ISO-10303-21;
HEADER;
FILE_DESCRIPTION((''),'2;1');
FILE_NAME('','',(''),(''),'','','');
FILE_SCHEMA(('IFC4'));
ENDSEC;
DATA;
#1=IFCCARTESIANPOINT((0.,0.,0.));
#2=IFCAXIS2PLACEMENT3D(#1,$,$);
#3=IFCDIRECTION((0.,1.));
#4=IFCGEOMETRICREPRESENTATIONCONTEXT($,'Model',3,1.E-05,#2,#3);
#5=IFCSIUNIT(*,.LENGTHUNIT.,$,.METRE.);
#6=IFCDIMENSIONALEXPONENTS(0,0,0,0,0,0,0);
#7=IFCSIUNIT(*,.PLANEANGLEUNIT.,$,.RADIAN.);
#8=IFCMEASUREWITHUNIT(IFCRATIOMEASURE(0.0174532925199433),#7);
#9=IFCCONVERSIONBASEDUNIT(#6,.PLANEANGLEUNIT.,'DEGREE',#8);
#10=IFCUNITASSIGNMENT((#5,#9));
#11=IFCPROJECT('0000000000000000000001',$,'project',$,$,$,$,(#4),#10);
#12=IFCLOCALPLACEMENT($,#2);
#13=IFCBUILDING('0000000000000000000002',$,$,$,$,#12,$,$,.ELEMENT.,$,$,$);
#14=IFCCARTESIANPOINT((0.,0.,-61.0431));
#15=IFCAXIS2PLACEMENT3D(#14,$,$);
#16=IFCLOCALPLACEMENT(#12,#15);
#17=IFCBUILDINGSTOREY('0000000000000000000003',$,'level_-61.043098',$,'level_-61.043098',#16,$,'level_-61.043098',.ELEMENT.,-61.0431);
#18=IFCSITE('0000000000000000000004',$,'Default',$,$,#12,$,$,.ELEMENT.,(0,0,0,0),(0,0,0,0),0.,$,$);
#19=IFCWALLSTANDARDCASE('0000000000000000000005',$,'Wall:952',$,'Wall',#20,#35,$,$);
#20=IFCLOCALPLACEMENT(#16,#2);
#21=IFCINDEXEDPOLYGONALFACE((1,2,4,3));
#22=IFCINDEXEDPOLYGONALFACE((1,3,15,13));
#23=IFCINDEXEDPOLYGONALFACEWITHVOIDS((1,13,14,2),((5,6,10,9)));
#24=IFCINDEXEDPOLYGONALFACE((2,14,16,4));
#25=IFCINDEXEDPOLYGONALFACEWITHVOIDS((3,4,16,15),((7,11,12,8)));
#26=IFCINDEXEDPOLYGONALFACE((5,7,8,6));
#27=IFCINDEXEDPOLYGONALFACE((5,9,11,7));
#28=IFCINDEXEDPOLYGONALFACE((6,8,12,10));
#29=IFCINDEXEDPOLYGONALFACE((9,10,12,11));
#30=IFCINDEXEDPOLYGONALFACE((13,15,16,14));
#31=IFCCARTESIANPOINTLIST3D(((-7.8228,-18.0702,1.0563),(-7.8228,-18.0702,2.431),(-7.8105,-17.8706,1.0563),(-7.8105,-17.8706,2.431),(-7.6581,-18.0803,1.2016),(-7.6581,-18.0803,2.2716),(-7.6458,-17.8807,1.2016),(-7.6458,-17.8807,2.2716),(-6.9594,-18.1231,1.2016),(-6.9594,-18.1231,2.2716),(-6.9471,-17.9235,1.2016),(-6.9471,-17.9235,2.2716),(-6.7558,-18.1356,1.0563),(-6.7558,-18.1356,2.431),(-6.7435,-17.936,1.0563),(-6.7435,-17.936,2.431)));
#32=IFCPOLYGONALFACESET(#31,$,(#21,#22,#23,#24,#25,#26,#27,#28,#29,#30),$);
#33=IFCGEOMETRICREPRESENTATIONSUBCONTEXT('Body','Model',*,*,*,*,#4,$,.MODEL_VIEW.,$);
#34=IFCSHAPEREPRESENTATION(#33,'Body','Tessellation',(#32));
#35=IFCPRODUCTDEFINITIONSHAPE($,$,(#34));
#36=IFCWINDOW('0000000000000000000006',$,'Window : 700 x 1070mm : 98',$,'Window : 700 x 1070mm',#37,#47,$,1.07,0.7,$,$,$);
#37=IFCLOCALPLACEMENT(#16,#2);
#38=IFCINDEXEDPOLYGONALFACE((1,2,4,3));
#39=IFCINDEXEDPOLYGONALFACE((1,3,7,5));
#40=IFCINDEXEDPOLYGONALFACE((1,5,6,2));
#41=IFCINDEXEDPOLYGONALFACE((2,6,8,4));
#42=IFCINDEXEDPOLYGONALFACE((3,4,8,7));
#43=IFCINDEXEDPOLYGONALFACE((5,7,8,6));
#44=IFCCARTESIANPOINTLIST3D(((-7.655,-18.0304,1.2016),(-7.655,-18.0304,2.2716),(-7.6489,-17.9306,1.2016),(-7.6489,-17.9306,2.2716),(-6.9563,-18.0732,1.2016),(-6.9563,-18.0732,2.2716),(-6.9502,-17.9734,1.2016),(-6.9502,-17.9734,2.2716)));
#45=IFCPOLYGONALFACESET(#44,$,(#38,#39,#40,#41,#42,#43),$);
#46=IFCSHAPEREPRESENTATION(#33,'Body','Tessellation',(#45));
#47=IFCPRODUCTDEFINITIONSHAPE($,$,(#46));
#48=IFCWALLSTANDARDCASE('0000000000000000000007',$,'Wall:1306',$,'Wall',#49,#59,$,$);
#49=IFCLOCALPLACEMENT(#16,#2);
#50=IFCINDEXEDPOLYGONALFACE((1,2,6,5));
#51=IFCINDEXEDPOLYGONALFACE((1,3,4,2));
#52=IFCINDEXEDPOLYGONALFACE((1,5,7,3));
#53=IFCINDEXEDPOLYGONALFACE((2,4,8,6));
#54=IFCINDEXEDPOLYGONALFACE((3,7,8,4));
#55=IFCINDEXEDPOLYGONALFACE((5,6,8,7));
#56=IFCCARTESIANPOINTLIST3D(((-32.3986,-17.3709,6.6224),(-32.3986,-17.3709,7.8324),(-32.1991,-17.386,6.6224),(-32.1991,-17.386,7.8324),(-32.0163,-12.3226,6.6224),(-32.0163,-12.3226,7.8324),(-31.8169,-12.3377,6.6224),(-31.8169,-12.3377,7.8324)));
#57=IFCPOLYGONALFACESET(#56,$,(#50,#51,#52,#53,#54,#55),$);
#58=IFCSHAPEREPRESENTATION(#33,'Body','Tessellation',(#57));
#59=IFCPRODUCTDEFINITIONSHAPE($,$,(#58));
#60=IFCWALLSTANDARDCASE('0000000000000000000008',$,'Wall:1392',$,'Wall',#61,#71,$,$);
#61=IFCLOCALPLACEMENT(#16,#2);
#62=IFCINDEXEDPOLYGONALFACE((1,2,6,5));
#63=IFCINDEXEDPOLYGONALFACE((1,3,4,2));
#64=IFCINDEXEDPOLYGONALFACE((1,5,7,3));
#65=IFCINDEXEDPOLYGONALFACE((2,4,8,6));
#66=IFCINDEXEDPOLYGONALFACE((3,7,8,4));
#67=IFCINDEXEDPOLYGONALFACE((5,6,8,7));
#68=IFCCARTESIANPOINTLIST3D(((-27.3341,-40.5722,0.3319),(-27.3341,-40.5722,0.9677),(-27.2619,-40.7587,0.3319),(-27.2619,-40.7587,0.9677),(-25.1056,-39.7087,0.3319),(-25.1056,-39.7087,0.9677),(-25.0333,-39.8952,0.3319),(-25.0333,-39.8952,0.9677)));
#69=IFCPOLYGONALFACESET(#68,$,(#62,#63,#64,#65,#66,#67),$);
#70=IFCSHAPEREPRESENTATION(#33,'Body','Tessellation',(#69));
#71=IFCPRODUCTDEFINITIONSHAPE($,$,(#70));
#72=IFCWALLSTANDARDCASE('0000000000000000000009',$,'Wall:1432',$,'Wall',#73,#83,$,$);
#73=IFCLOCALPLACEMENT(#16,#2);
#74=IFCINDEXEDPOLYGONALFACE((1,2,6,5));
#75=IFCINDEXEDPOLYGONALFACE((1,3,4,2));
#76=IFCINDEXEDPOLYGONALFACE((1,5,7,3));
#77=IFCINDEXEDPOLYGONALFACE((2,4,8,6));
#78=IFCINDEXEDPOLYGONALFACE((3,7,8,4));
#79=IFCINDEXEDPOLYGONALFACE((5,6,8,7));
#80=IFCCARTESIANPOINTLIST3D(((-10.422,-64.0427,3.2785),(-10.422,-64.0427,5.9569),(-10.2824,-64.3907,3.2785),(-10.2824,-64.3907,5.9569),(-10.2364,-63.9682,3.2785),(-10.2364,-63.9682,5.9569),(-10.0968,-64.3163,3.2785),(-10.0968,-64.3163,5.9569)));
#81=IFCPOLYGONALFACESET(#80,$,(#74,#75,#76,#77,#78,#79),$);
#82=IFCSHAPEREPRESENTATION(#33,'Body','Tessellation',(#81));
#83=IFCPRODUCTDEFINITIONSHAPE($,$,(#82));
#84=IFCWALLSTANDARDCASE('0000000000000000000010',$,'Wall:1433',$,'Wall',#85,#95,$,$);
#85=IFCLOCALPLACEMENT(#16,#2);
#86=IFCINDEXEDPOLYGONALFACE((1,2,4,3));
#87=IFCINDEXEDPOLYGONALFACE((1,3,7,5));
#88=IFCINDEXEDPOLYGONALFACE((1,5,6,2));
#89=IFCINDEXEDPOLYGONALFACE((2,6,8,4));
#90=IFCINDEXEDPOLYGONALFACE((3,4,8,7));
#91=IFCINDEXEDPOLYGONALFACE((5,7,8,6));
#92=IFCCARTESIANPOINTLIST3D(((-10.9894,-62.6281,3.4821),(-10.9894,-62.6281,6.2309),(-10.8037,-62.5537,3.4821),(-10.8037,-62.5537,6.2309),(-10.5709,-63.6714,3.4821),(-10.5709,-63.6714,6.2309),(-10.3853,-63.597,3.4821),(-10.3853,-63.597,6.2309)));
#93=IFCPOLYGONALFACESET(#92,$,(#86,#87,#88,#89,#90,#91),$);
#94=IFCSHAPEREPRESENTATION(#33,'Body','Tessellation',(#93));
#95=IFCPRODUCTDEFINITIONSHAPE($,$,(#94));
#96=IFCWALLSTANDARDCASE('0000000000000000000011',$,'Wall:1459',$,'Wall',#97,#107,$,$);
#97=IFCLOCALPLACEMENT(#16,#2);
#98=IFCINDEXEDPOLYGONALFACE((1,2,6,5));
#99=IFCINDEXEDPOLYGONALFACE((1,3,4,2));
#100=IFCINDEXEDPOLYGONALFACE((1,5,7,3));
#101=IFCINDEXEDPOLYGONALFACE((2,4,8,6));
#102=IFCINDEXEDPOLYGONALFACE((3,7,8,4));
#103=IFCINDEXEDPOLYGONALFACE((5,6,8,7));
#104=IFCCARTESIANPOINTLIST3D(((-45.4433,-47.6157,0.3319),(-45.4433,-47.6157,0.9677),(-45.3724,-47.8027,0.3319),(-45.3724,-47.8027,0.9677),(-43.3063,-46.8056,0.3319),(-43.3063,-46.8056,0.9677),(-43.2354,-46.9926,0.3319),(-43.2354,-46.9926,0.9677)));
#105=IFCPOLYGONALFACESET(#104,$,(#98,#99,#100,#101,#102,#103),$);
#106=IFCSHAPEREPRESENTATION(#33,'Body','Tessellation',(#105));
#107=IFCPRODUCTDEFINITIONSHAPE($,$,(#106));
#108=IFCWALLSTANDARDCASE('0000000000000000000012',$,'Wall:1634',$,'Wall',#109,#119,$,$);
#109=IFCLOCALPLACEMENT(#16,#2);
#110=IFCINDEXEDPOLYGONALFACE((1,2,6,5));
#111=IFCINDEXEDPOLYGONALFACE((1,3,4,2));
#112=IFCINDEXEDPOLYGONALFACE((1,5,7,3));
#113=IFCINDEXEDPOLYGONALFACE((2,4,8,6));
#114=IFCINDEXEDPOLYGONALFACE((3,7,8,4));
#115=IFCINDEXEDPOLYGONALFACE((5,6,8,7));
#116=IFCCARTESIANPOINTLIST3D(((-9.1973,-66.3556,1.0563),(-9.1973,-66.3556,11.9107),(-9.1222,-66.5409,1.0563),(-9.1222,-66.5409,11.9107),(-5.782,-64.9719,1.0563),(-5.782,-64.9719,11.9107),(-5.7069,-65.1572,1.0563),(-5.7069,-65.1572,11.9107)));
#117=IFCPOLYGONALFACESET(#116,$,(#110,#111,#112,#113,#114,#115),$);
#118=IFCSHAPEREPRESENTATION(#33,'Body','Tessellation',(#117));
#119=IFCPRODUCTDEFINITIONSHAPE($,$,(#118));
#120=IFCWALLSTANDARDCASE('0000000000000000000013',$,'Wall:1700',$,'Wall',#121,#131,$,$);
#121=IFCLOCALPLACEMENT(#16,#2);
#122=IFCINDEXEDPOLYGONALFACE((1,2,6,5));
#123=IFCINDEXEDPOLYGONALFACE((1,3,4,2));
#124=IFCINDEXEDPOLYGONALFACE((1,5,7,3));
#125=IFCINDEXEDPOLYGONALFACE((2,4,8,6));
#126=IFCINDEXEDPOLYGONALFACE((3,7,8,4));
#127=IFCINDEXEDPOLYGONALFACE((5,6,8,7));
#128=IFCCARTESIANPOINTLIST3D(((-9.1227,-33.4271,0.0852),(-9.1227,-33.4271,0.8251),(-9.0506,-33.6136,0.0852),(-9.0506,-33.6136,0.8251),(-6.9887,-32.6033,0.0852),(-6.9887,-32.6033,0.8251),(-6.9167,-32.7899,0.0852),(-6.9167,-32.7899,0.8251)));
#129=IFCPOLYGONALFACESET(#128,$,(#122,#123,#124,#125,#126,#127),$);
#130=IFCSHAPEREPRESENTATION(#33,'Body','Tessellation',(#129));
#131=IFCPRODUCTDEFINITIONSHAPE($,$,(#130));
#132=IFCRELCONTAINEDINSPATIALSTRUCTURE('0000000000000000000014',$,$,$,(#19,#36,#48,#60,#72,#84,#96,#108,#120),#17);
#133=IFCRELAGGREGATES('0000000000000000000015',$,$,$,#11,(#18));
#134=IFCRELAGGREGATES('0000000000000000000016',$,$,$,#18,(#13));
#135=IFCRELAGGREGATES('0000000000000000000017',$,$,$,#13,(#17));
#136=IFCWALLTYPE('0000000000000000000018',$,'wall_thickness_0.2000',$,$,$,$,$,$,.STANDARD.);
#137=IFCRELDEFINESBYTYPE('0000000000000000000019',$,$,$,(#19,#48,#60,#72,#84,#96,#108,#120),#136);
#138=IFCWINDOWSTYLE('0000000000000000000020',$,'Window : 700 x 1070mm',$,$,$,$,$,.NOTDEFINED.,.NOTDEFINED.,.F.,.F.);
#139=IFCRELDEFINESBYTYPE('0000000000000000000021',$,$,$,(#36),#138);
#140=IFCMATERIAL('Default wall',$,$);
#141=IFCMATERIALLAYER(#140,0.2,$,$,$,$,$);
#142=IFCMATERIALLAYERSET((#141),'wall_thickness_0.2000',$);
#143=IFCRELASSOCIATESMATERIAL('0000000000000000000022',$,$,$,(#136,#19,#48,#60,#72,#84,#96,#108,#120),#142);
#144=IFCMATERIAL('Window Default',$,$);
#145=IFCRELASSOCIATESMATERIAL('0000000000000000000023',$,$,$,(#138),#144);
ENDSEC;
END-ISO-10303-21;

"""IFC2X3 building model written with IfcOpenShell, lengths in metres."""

from ifc_helpers import new_model, entity, si_unit, converted_unit, direction, frame, frame_2d, origin, origin_2d_with_axis, place, context, subcontext, project, spatial, polyline, rectangle, outline, extrude, source, transform, mapped, material, layer, layer_set, layer_usage, type_object, type_shapes, element, fill, save


model = new_model("IFC2X3")

# Units and contexts
model_context = context("Model", 3, precision=1e-05, world=origin(), true_north=direction((0.0, 1.0)))
body_context = subcontext(model_context, "Body", "Model", "MODEL_VIEW")
ifc_project = project(units=[si_unit("LENGTHUNIT", "METRE"), converted_unit("PLANEANGLEUNIT", "DEGREE", entity("IfcRatioMeasure", 0.0174532925199433), si_unit("PLANEANGLEUNIT", "RADIAN"), dimensions=[0, 0, 0, 0, 0, 0, 0])], contexts=[model_context])

# Site, building, storey
placement_1 = place(None, origin())
site = spatial("IfcSite", under=ifc_project, at=placement_1, Name="Default", CompositionType="ELEMENT", RefLatitude=(0, 0, 0, 0), RefLongitude=(0, 0, 0, 0), RefElevation=0.0)
building = spatial("IfcBuilding", under=site, at=placement_1, CompositionType="ELEMENT")
storey_placement = place(placement_1, frame((0.0, 0.0, -61.0431)))
storey = spatial("IfcBuildingStorey", under=building, at=storey_placement, Name="level_-61.043098", ObjectType="level_-61.043098", LongName="level_-61.043098", CompositionType="ELEMENT", Elevation=-61.0431)

# Shared definitions
ifc_material_1 = material(Name="Default wall")
ifc_layer = layer(ifc_material_1, 0.2)
ifc_layer_set = layer_set([ifc_layer], Name="wall_thickness_0.2000")
ifc_layer_usage = layer_usage(ifc_layer_set, "AXIS2", "POSITIVE", -0.1)
wall_type = type_object("IfcWallType", Name="wall_thickness_0.2000", PredefinedType="STANDARD", material=ifc_layer_set)
ifc_material_2 = material(Name="Window Default")

# Wall, opening, window
placement_2 = place(placement_1, frame((0.0, 0.0, -59.9868)))
wall_1_placement = place(placement_2, frame((-7.8166, -17.9704, 0.0), z_axis=(0.0, 0.0, 1.0), x_axis=(0.998125, -0.061212, 0.0)))
wall_1 = element("IfcWallStandardCase", 1, at=wall_1_placement, inside=storey, type_object=wall_type, material=ifc_layer_usage, Name="Wall:952", ObjectType="Wall", context=body_context, shape_type="SweptSolid", body=[
    extrude(outline(polyline([(1.069, -0.1), (1.069, 0.1), (0.0, 0.1), (0.0, -0.1), (1.069, -0.1)])), origin(), (0.0, 0.0, 1.0), 1.3747),
])
opening_1_placement = place(wall_1_placement, frame((0.165, -0.1, 0.1452)))
opening_1 = element("IfcOpeningElement", 2, at=opening_1_placement, cuts=wall_1, ObjectType="Opening", context=body_context, shape_type="SweptSolid", body=[
    extrude(rectangle(XDim=0.7, YDim=1.07, at=frame_2d((0.535, 0.35), x_axis=(0.0, 1.0))), frame((0.0, 0.0, 0.0), z_axis=(0.0, 1.0, 0.0), x_axis=(0.0, 0.0, 1.0)), (0.0, 0.0, 1.0), 0.2),
])
window_style_1 = type_object("IfcWindowStyle", Name="Window : 700 x 1070mm", ConstructionType="NOTDEFINED", OperationType="NOTDEFINED", ParameterTakesPrecedence=False, Sizeable=False, material=ifc_material_2)
shared_shape_1 = source(origin(), body_context, "Body", "SweptSolid", [
    extrude(rectangle(XDim=0.1, YDim=0.7, at=origin_2d_with_axis()), frame((0.35, 0.1, 0.0), z_axis=(0.0, 0.0, 1.0), x_axis=(0.0, 1.0, 0.0)), (0.0, 0.0, 1.0), 1.07),
])
type_shapes(window_style_1, [shared_shape_1])
window_1_placement = place(opening_1_placement, origin())
window_1 = element("IfcWindow", 3, at=window_1_placement, inside=storey, type_object=window_style_1, Name="Window : 700 x 1070mm : 98", ObjectType="Window : 700 x 1070mm", OverallHeight=1.07, OverallWidth=0.7, context=body_context, shape_type="MappedRepresentation", body=[
    mapped(shared_shape_1, transform((0.0, 0.0, 0.0), scale=1.0)),
])
fill(opening_1, window_1)

# Walls
placement_3 = place(placement_1, frame((0.0, 0.0, -54.4207)))
wall_2_placement = place(placement_3, frame((-32.2989, -17.3785, 0.0), z_axis=(0.0, 0.0, 1.0), x_axis=(0.075507, 0.997145, 0.0)))
element("IfcWallStandardCase", 4, at=wall_2_placement, inside=storey, type_object=wall_type, material=ifc_layer_usage, Name="Wall:1306", ObjectType="Wall", context=body_context, shape_type="SweptSolid", body=[
    extrude(outline(polyline([(5.0628, -0.1), (5.0628, 0.1), (0.0, 0.1), (0.0, -0.1), (5.0628, -0.1)])), origin(), (0.0, 0.0, 1.0), 1.21),
])
placement_4 = place(placement_1, frame((0.0, 0.0, -60.7112)))
wall_3_placement = place(placement_4, frame((-27.298, -40.6655, 0.0), z_axis=(0.0, 0.0, 1.0), x_axis=(0.932453, 0.361292, 0.0)))
element("IfcWallStandardCase", 5, at=wall_3_placement, inside=storey, type_object=wall_type, material=ifc_layer_usage, Name="Wall:1392", ObjectType="Wall", context=body_context, shape_type="SweptSolid", body=[
    extrude(outline(polyline([(2.39, -0.1), (2.39, 0.1), (0.0, 0.1), (0.0, -0.1), (2.39, -0.1)])), origin(), (0.0, 0.0, 1.0), 0.6358),
])
placement_5 = place(placement_1, frame((0.0, 0.0, -57.7646)))
wall_4_placement = place(placement_5, frame((-10.1896, -64.3535, 0.0), z_axis=(0.0, 0.0, 1.0), x_axis=(-0.372239, 0.928137, 0.0)))
element("IfcWallStandardCase", 6, at=wall_4_placement, inside=storey, type_object=wall_type, material=ifc_layer_usage, Name="Wall:1432", ObjectType="Wall", context=body_context, shape_type="SweptSolid", body=[
    extrude(outline(polyline([(0.375, -0.1), (0.375, 0.1), (0.0, 0.1), (0.0, -0.1), (0.375, -0.1)])), origin(), (0.0, 0.0, 1.0), 2.6784),
])
placement_6 = place(placement_1, frame((0.0, 0.0, -57.561)))
wall_5_placement = place(placement_6, frame((-10.4781, -63.6342, 0.0), z_axis=(0.0, 0.0, 1.0), x_axis=(-0.37224, 0.928137, 0.0)))
element("IfcWallStandardCase", 7, at=wall_5_placement, inside=storey, type_object=wall_type, material=ifc_layer_usage, Name="Wall:1433", ObjectType="Wall", context=body_context, shape_type="SweptSolid", body=[
    extrude(outline(polyline([(1.1241, -0.1), (1.1241, 0.1), (0.0, 0.1), (0.0, -0.1), (1.1241, -0.1)])), origin(), (0.0, 0.0, 1.0), 2.7488),
])
placement_7 = place(placement_1, frame((0.0, 0.0, -60.7112)))
wall_6_placement = place(placement_7, frame((-45.4078, -47.7092, 0.0), z_axis=(0.0, 0.0, 1.0), x_axis=(0.935067, 0.35447, 0.0)))
element("IfcWallStandardCase", 8, at=wall_6_placement, inside=storey, type_object=wall_type, material=ifc_layer_usage, Name="Wall:1459", ObjectType="Wall", context=body_context, shape_type="SweptSolid", body=[
    extrude(outline(polyline([(2.2854, -0.1), (2.2854, 0.1), (0.0, 0.1), (0.0, -0.1), (2.2854, -0.1)])), origin(), (0.0, 0.0, 1.0), 0.6358),
])
placement_8 = place(placement_1, frame((0.0, 0.0, -59.9868)))
wall_7_placement = place(placement_8, frame((-9.1598, -66.4483, 0.0), z_axis=(0.0, 0.0, 1.0), x_axis=(0.926825, 0.375495, 0.0)))
element("IfcWallStandardCase", 9, at=wall_7_placement, inside=storey, type_object=wall_type, material=ifc_layer_usage, Name="Wall:1634", ObjectType="Wall", context=body_context, shape_type="SweptSolid", body=[
    extrude(outline(polyline([(3.685, -0.1), (3.685, 0.1), (0.0, 0.1), (0.0, -0.1), (3.685, -0.1)])), origin(), (0.0, 0.0, 1.0), 10.8544),
])
placement_9 = place(placement_1, frame((0.0, 0.0, -60.9579)))
wall_8_placement = place(placement_9, frame((-9.0866, -33.5203, 0.0), z_axis=(0.0, 0.0, 1.0), x_axis=(0.932907, 0.360117, 0.0)))
element("IfcWallStandardCase", 10, at=wall_8_placement, inside=storey, type_object=wall_type, material=ifc_layer_usage, Name="Wall:1700", ObjectType="Wall", context=body_context, shape_type="SweptSolid", body=[
    extrude(outline(polyline([(2.2874, -0.1), (2.2874, 0.1), (0.0, 0.1), (0.0, -0.1), (2.2874, -0.1)])), origin(), (0.0, 0.0, 1.0), 0.7399),
])

save(model, "model.ifc")
